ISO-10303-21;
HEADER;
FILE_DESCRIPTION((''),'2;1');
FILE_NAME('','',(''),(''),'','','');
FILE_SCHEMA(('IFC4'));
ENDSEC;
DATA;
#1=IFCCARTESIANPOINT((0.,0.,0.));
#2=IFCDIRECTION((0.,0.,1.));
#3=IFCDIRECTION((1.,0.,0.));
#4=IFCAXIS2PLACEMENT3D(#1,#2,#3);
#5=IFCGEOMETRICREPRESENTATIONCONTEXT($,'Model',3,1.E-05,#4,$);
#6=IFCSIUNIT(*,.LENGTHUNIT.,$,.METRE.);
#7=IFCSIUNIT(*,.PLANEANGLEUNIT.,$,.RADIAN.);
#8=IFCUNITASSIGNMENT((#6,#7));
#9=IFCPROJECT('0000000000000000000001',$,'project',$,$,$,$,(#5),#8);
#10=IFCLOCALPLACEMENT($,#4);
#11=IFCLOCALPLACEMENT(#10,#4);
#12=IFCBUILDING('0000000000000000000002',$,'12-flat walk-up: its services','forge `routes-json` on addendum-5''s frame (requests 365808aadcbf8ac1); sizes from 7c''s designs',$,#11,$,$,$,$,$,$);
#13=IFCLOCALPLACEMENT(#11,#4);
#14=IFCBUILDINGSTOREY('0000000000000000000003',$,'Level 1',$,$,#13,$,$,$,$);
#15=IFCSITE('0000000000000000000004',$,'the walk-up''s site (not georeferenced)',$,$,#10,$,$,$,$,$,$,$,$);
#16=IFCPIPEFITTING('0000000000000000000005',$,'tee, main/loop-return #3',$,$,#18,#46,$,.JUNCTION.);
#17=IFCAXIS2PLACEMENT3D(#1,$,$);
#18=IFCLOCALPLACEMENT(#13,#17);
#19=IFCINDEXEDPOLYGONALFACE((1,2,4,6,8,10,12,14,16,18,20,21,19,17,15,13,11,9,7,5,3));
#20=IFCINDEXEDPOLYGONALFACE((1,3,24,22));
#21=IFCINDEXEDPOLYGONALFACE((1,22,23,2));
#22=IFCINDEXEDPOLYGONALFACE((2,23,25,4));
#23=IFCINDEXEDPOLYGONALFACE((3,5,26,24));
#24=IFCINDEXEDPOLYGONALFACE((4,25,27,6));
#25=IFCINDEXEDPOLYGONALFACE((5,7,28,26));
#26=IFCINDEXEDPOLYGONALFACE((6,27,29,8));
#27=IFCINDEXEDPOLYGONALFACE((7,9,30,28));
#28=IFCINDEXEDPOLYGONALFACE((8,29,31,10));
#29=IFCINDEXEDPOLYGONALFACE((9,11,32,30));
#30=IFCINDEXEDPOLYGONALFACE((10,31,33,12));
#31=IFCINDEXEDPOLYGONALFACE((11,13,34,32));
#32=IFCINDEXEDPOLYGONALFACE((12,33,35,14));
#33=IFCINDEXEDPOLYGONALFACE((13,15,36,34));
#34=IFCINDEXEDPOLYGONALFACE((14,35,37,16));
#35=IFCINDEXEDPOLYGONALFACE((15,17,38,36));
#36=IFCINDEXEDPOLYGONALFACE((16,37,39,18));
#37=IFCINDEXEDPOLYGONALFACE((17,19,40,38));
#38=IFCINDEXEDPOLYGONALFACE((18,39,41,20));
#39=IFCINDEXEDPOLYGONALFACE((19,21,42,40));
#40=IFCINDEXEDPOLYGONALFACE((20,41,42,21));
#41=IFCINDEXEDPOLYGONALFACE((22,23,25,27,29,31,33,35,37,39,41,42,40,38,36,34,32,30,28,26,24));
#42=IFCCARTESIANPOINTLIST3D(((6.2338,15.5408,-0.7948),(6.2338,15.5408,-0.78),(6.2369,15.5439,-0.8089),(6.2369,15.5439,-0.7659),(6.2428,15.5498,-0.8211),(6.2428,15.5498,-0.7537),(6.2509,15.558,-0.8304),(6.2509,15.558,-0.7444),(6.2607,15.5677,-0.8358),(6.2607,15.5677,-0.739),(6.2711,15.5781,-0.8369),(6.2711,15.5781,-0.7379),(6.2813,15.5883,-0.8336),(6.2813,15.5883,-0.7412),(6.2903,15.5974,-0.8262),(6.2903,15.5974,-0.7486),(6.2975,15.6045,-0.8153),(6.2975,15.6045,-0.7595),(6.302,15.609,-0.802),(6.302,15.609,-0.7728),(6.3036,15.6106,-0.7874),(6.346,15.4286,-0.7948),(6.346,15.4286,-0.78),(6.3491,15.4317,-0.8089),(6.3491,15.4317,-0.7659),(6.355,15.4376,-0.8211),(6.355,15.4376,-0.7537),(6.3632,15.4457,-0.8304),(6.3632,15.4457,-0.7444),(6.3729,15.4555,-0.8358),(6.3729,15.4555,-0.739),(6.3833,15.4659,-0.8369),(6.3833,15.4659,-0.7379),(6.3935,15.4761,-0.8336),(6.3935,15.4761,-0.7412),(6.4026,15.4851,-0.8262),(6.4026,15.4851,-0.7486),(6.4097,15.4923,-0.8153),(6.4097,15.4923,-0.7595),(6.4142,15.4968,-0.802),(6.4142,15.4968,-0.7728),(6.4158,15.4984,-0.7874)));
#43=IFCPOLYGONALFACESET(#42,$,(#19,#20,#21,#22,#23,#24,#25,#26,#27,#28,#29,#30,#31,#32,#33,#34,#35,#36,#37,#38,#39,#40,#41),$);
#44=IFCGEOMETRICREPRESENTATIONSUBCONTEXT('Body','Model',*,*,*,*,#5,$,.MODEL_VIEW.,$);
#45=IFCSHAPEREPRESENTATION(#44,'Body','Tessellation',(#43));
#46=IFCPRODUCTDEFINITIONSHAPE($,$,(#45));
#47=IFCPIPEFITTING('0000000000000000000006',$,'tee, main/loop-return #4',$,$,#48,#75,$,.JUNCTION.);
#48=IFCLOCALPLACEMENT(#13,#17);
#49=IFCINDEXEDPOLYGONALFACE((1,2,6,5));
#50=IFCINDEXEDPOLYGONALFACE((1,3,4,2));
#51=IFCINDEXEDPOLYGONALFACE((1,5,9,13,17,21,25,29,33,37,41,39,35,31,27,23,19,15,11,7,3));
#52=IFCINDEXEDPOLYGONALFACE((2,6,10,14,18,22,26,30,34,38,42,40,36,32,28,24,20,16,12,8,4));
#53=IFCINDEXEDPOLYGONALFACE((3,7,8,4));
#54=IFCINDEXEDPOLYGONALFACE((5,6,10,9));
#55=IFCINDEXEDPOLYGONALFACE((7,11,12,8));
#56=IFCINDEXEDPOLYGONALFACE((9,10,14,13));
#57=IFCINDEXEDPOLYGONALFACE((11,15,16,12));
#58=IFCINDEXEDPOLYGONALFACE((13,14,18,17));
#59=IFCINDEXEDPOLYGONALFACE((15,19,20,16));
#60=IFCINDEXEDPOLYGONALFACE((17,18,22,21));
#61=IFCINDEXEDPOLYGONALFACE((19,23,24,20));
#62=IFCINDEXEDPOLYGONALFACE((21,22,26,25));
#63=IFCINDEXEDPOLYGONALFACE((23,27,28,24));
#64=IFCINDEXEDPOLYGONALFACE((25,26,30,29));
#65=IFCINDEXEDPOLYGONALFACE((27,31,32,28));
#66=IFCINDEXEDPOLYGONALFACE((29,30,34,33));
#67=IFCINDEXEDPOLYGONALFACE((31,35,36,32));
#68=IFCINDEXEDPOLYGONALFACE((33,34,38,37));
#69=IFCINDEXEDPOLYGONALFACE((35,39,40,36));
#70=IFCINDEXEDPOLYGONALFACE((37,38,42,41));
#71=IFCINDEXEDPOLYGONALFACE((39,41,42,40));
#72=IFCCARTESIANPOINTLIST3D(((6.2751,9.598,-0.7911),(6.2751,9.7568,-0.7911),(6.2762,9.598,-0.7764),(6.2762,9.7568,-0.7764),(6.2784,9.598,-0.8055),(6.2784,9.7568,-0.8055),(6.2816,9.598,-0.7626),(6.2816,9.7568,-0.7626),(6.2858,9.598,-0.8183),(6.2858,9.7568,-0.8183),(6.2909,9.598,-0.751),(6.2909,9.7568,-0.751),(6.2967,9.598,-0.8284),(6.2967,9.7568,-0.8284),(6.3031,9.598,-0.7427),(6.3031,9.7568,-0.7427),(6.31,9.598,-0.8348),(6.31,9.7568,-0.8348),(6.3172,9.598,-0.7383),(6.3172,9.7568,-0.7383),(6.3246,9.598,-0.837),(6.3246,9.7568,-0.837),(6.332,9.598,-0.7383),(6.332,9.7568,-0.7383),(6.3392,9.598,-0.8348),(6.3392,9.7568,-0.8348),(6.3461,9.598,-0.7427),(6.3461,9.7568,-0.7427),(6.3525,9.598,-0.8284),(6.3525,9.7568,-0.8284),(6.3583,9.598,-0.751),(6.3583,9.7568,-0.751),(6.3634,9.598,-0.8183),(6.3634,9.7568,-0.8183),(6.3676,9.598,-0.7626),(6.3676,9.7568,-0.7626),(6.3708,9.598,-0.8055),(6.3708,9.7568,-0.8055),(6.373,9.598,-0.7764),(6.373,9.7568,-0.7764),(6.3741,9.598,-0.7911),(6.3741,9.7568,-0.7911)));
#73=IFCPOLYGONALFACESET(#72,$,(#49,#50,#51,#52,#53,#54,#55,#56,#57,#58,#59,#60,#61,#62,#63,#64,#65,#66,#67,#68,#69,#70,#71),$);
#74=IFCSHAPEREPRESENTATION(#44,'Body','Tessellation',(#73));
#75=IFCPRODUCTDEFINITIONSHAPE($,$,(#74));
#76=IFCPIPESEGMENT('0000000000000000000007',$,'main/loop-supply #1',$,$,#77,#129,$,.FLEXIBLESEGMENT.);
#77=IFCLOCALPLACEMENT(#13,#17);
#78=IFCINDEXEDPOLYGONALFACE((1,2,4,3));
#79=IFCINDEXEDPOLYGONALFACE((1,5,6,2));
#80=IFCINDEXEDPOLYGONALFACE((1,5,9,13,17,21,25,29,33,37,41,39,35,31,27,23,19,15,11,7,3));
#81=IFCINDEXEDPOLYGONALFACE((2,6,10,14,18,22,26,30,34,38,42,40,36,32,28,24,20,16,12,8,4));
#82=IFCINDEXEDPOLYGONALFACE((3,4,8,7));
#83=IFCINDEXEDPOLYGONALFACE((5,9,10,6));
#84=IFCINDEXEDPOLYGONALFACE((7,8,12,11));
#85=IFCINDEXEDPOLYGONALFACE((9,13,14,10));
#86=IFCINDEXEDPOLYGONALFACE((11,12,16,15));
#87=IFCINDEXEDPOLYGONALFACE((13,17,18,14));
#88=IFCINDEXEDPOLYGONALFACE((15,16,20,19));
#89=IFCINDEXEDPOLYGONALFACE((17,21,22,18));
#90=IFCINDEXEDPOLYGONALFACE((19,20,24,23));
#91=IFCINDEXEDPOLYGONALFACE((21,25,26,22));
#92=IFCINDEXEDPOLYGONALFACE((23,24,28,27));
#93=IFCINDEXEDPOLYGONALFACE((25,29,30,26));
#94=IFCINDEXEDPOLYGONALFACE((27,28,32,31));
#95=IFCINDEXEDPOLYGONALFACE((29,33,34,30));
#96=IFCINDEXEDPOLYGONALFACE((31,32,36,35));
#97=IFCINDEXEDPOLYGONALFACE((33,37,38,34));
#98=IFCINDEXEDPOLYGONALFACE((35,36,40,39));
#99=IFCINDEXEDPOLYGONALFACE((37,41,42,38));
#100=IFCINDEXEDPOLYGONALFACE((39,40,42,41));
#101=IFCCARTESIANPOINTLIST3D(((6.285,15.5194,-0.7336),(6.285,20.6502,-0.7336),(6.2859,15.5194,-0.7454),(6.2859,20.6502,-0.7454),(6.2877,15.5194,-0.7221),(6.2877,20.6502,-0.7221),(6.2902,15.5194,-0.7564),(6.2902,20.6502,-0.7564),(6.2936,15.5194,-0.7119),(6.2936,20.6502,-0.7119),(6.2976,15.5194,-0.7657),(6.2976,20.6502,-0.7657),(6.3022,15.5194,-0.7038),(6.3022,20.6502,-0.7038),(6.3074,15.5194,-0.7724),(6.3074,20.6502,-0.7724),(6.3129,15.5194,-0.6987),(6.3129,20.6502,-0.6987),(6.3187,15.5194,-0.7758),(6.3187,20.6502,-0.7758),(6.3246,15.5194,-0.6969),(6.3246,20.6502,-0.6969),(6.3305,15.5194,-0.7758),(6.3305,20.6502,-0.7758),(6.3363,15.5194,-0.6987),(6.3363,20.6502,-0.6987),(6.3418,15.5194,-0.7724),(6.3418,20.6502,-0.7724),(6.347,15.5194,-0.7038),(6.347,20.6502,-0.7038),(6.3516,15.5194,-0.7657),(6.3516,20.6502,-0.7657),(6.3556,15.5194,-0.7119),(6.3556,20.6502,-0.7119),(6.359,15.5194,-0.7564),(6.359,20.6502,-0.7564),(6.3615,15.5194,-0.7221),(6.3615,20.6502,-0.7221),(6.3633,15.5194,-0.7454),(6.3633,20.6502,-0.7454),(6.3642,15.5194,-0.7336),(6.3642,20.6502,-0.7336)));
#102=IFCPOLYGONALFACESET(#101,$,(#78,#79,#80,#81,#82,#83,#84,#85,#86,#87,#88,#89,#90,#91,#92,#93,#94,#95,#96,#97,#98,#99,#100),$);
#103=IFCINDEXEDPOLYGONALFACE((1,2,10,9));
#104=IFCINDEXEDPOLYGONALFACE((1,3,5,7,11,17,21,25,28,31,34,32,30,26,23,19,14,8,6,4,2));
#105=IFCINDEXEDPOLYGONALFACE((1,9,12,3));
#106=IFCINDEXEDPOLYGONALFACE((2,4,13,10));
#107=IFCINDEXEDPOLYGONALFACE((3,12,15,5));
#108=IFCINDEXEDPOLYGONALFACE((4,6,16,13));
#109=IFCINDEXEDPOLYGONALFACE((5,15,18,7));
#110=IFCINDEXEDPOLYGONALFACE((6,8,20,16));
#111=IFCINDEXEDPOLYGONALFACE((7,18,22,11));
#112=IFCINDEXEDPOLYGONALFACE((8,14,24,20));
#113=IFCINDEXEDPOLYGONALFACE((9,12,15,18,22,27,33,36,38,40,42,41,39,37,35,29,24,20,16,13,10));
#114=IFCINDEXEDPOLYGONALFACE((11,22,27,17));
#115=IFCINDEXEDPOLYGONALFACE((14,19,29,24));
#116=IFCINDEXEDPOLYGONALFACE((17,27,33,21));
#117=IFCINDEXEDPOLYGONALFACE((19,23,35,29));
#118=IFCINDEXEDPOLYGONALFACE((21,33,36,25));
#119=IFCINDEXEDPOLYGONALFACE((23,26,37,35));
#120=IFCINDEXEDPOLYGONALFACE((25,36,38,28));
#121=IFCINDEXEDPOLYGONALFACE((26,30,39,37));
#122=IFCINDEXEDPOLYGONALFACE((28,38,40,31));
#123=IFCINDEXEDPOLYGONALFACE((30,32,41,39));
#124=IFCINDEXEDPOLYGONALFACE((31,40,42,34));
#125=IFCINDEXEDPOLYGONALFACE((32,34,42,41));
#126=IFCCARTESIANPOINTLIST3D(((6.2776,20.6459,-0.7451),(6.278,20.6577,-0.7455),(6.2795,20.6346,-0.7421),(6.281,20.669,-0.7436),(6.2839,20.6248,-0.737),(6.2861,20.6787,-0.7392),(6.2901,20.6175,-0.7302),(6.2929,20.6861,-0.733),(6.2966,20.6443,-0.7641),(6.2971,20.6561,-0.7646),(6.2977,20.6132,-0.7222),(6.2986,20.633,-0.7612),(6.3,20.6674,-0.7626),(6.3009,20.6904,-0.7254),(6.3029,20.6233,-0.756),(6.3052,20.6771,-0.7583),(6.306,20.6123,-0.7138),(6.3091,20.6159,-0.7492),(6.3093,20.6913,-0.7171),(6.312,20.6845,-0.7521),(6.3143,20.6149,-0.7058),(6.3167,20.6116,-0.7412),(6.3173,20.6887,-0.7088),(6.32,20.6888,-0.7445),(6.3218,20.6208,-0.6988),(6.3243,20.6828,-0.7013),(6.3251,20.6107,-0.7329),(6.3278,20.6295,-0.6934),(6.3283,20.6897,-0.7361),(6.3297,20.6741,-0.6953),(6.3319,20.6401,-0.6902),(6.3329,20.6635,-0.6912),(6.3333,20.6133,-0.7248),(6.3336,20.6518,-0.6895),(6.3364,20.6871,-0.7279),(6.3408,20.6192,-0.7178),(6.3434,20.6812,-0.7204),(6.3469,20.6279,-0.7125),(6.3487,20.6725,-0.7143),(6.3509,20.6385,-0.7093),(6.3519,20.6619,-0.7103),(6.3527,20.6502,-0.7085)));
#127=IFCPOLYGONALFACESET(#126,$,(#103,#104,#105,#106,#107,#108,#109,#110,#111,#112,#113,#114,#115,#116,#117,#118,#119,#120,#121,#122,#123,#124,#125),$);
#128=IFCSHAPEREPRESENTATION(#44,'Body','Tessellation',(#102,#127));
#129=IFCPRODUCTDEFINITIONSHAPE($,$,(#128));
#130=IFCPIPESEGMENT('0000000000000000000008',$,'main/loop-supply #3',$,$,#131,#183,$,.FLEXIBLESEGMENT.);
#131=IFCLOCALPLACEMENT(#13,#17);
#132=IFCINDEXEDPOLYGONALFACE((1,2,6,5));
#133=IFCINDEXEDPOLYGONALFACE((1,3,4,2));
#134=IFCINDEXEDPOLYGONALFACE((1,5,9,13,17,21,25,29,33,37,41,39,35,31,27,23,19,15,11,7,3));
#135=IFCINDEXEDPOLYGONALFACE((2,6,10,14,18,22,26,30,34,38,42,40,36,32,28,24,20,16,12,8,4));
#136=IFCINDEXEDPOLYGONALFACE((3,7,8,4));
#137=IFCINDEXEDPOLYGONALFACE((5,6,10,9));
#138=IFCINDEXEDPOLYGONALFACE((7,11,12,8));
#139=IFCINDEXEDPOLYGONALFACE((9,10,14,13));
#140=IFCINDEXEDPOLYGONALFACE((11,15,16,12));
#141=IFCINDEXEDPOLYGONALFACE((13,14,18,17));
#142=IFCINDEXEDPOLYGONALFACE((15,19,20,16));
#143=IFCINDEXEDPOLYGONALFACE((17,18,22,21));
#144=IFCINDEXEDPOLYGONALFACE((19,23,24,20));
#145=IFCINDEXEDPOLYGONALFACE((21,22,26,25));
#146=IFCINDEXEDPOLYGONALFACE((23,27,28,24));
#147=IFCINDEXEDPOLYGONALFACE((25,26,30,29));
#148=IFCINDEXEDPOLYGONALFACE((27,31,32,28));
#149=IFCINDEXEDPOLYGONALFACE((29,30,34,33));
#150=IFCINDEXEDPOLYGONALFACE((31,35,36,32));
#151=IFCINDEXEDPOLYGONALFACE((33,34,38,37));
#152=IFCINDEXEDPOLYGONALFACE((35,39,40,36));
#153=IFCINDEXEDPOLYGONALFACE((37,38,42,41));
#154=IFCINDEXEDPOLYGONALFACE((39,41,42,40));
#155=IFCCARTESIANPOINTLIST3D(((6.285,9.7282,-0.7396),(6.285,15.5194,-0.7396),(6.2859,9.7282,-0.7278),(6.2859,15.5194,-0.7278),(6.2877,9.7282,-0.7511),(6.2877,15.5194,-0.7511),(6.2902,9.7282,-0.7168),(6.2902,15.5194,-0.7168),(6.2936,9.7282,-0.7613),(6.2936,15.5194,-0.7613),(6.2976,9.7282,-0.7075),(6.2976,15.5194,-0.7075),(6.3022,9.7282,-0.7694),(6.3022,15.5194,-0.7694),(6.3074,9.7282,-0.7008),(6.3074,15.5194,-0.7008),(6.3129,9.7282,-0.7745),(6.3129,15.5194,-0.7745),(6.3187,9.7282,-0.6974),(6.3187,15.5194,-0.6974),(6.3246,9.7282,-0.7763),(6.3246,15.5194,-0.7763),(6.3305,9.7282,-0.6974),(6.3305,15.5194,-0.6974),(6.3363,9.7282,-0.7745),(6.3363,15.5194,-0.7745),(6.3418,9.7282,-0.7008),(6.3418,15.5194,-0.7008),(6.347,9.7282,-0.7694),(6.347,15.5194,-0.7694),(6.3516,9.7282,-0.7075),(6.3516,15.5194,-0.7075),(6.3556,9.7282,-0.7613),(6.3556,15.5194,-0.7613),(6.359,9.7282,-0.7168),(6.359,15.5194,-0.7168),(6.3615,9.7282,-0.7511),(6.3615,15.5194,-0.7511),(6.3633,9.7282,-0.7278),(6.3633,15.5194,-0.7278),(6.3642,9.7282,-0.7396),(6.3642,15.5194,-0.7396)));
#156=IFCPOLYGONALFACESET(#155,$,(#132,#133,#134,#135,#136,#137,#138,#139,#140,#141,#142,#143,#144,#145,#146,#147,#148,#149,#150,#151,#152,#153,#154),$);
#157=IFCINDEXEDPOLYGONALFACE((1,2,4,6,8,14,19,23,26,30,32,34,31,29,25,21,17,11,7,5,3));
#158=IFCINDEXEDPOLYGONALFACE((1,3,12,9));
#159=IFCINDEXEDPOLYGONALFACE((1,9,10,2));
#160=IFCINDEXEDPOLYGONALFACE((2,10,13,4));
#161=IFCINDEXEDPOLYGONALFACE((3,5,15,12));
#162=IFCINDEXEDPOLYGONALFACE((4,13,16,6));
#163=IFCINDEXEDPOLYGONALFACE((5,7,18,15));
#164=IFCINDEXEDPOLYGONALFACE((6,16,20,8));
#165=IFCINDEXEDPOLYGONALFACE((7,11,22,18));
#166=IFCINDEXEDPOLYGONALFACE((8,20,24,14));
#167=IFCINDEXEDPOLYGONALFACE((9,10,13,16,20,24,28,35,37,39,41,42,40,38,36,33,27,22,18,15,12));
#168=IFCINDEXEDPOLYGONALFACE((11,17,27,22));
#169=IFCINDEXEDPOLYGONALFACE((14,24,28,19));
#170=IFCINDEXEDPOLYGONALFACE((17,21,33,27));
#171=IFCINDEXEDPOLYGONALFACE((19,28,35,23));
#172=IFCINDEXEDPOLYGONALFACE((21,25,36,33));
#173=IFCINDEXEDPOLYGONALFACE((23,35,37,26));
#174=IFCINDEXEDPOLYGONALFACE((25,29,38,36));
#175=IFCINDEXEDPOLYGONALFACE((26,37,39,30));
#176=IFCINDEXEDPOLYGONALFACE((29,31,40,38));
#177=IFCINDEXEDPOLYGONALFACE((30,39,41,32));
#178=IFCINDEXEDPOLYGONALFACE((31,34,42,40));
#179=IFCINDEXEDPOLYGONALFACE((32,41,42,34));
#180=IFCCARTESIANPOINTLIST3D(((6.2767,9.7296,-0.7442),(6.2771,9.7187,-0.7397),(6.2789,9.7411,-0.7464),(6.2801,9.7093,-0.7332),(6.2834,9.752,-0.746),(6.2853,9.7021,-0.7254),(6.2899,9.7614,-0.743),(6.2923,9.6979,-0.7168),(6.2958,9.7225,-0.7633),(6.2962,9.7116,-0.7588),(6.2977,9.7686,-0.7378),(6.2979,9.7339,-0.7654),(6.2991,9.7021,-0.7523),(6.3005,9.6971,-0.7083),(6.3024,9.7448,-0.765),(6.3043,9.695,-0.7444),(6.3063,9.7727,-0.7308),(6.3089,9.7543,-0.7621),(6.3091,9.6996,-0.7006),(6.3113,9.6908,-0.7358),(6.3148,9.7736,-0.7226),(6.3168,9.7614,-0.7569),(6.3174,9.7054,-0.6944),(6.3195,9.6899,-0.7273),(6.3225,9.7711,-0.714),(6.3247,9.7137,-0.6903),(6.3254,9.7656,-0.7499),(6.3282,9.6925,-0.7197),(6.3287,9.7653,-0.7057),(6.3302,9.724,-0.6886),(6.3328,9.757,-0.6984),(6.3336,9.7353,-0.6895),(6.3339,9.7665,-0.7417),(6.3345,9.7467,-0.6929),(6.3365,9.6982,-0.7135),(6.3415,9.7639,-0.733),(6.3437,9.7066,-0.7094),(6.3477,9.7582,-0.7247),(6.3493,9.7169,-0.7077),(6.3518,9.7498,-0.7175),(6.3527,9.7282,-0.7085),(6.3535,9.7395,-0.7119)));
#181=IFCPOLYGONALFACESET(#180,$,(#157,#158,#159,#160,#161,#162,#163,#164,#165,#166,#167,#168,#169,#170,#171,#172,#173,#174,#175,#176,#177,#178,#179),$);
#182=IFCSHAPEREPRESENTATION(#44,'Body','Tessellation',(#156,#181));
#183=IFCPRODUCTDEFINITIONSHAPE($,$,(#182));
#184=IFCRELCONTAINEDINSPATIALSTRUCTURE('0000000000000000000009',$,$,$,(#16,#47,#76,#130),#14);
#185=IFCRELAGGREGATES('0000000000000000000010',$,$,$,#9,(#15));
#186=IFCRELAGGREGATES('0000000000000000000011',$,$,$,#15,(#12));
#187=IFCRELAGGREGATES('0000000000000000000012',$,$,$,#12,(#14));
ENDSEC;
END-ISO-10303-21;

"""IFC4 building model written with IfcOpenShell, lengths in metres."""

from ifc_helpers import new_model, entity, si_unit, frame, origin_with_axes, place, context, subcontext, project, spatial, element, save


model = new_model("IFC4")

# Units and contexts
model_context = context("Model", 3, precision=1e-05, world=origin_with_axes())
body_context = subcontext(model_context, "Body", "Model", "MODEL_VIEW")
ifc_project = project(units=[si_unit("LENGTHUNIT", "METRE"), si_unit("PLANEANGLEUNIT", "RADIAN")], contexts=[model_context])

# Site, building, storey
site_placement = place(None, origin_with_axes())
site = spatial("IfcSite", under=ifc_project, at=site_placement, Name="the walk-up's site (not georeferenced)")
building_placement = place(site_placement, origin_with_axes())
building = spatial("IfcBuilding", under=site, at=building_placement, Name="12-flat walk-up: its services", Description="forge `routes-json` on addendum-5's frame (requests 365808aadcbf8ac1); sizes from 7c's designs")
storey_placement = place(building_placement, origin_with_axes())
storey = spatial("IfcBuildingStorey", under=building, at=storey_placement, Name="Level 1")

# Pipe fittings
pipe_fitting_1_placement = place(storey_placement, frame((6.3807, 15.4633, -0.7874), z_axis=(0.0, 0.0, 1.0), x_axis=(1.0, 0.0, 0.0)))
element("IfcPipeFitting", 1, at=pipe_fitting_1_placement, inside=storey, Name="tee, main/loop-return #3", PredefinedType="JUNCTION", context=body_context, shape_type="AdvancedSweptSolid", body=[
    entity("IfcSweptDiskSolid", entity("IfcPolyline", [entity("IfcCartesianPoint", [0.0, 0.0, 0.0]), entity("IfcCartesianPoint", [-0.1123, 0.1123, 0.0])]), 0.0496),
])
pipe_fitting_2_placement = place(storey_placement, frame((6.3246, 9.7568, -0.7874), z_axis=(0.0, 0.0, 1.0), x_axis=(1.0, 0.0, 0.0)))
element("IfcPipeFitting", 2, at=pipe_fitting_2_placement, inside=storey, Name="tee, main/loop-return #4", PredefinedType="JUNCTION", context=body_context, shape_type="AdvancedSweptSolid", body=[
    entity("IfcSweptDiskSolid", entity("IfcPolyline", [entity("IfcCartesianPoint", [0.0, 0.0, 0.0]), entity("IfcCartesianPoint", [0.0, -0.1588, 0.0])]), 0.0496),
])

# Pipe segments
pipe_segment_1_placement = place(storey_placement, frame((6.3246, 15.5194, -0.7366), z_axis=(0.0, 0.0, 1.0), x_axis=(1.0, 0.0, 0.0)))
element("IfcPipeSegment", 3, at=pipe_segment_1_placement, inside=storey, Name="main/loop-supply #1", PredefinedType="FLEXIBLESEGMENT", context=body_context, shape_type="AdvancedSweptSolid", body=[
    entity("IfcSweptDiskSolid", entity("IfcPolyline", [entity("IfcCartesianPoint", [0.0, 0.0, 0.0]), entity("IfcCartesianPoint", [0.0, 5.1308, 0.0])]), 0.0397),
    entity("IfcSweptDiskSolid", entity("IfcPolyline", [entity("IfcCartesianPoint", [0.0, 5.1308, 0.0]), entity("IfcCartesianPoint", [-0.019, 5.1324, 0.0191])]), 0.0397),
])
pipe_segment_2_placement = place(storey_placement, frame((6.3246, 15.5194, -0.7366), z_axis=(0.0, 0.0, 1.0), x_axis=(1.0, 0.0, 0.0)))
element("IfcPipeSegment", 4, at=pipe_segment_2_placement, inside=storey, Name="main/loop-supply #3", PredefinedType="FLEXIBLESEGMENT", context=body_context, shape_type="AdvancedSweptSolid", body=[
    entity("IfcSweptDiskSolid", entity("IfcPolyline", [entity("IfcCartesianPoint", [0.0, 0.0, 0.0]), entity("IfcCartesianPoint", [0.0, -5.7912, 0.0])]), 0.0397),
    entity("IfcSweptDiskSolid", entity("IfcPolyline", [entity("IfcCartesianPoint", [0.0, -5.7912, 0.0]), entity("IfcCartesianPoint", [-0.019, -5.7841, 0.0191])]), 0.0397),
])

save(model, "model.ifc")
